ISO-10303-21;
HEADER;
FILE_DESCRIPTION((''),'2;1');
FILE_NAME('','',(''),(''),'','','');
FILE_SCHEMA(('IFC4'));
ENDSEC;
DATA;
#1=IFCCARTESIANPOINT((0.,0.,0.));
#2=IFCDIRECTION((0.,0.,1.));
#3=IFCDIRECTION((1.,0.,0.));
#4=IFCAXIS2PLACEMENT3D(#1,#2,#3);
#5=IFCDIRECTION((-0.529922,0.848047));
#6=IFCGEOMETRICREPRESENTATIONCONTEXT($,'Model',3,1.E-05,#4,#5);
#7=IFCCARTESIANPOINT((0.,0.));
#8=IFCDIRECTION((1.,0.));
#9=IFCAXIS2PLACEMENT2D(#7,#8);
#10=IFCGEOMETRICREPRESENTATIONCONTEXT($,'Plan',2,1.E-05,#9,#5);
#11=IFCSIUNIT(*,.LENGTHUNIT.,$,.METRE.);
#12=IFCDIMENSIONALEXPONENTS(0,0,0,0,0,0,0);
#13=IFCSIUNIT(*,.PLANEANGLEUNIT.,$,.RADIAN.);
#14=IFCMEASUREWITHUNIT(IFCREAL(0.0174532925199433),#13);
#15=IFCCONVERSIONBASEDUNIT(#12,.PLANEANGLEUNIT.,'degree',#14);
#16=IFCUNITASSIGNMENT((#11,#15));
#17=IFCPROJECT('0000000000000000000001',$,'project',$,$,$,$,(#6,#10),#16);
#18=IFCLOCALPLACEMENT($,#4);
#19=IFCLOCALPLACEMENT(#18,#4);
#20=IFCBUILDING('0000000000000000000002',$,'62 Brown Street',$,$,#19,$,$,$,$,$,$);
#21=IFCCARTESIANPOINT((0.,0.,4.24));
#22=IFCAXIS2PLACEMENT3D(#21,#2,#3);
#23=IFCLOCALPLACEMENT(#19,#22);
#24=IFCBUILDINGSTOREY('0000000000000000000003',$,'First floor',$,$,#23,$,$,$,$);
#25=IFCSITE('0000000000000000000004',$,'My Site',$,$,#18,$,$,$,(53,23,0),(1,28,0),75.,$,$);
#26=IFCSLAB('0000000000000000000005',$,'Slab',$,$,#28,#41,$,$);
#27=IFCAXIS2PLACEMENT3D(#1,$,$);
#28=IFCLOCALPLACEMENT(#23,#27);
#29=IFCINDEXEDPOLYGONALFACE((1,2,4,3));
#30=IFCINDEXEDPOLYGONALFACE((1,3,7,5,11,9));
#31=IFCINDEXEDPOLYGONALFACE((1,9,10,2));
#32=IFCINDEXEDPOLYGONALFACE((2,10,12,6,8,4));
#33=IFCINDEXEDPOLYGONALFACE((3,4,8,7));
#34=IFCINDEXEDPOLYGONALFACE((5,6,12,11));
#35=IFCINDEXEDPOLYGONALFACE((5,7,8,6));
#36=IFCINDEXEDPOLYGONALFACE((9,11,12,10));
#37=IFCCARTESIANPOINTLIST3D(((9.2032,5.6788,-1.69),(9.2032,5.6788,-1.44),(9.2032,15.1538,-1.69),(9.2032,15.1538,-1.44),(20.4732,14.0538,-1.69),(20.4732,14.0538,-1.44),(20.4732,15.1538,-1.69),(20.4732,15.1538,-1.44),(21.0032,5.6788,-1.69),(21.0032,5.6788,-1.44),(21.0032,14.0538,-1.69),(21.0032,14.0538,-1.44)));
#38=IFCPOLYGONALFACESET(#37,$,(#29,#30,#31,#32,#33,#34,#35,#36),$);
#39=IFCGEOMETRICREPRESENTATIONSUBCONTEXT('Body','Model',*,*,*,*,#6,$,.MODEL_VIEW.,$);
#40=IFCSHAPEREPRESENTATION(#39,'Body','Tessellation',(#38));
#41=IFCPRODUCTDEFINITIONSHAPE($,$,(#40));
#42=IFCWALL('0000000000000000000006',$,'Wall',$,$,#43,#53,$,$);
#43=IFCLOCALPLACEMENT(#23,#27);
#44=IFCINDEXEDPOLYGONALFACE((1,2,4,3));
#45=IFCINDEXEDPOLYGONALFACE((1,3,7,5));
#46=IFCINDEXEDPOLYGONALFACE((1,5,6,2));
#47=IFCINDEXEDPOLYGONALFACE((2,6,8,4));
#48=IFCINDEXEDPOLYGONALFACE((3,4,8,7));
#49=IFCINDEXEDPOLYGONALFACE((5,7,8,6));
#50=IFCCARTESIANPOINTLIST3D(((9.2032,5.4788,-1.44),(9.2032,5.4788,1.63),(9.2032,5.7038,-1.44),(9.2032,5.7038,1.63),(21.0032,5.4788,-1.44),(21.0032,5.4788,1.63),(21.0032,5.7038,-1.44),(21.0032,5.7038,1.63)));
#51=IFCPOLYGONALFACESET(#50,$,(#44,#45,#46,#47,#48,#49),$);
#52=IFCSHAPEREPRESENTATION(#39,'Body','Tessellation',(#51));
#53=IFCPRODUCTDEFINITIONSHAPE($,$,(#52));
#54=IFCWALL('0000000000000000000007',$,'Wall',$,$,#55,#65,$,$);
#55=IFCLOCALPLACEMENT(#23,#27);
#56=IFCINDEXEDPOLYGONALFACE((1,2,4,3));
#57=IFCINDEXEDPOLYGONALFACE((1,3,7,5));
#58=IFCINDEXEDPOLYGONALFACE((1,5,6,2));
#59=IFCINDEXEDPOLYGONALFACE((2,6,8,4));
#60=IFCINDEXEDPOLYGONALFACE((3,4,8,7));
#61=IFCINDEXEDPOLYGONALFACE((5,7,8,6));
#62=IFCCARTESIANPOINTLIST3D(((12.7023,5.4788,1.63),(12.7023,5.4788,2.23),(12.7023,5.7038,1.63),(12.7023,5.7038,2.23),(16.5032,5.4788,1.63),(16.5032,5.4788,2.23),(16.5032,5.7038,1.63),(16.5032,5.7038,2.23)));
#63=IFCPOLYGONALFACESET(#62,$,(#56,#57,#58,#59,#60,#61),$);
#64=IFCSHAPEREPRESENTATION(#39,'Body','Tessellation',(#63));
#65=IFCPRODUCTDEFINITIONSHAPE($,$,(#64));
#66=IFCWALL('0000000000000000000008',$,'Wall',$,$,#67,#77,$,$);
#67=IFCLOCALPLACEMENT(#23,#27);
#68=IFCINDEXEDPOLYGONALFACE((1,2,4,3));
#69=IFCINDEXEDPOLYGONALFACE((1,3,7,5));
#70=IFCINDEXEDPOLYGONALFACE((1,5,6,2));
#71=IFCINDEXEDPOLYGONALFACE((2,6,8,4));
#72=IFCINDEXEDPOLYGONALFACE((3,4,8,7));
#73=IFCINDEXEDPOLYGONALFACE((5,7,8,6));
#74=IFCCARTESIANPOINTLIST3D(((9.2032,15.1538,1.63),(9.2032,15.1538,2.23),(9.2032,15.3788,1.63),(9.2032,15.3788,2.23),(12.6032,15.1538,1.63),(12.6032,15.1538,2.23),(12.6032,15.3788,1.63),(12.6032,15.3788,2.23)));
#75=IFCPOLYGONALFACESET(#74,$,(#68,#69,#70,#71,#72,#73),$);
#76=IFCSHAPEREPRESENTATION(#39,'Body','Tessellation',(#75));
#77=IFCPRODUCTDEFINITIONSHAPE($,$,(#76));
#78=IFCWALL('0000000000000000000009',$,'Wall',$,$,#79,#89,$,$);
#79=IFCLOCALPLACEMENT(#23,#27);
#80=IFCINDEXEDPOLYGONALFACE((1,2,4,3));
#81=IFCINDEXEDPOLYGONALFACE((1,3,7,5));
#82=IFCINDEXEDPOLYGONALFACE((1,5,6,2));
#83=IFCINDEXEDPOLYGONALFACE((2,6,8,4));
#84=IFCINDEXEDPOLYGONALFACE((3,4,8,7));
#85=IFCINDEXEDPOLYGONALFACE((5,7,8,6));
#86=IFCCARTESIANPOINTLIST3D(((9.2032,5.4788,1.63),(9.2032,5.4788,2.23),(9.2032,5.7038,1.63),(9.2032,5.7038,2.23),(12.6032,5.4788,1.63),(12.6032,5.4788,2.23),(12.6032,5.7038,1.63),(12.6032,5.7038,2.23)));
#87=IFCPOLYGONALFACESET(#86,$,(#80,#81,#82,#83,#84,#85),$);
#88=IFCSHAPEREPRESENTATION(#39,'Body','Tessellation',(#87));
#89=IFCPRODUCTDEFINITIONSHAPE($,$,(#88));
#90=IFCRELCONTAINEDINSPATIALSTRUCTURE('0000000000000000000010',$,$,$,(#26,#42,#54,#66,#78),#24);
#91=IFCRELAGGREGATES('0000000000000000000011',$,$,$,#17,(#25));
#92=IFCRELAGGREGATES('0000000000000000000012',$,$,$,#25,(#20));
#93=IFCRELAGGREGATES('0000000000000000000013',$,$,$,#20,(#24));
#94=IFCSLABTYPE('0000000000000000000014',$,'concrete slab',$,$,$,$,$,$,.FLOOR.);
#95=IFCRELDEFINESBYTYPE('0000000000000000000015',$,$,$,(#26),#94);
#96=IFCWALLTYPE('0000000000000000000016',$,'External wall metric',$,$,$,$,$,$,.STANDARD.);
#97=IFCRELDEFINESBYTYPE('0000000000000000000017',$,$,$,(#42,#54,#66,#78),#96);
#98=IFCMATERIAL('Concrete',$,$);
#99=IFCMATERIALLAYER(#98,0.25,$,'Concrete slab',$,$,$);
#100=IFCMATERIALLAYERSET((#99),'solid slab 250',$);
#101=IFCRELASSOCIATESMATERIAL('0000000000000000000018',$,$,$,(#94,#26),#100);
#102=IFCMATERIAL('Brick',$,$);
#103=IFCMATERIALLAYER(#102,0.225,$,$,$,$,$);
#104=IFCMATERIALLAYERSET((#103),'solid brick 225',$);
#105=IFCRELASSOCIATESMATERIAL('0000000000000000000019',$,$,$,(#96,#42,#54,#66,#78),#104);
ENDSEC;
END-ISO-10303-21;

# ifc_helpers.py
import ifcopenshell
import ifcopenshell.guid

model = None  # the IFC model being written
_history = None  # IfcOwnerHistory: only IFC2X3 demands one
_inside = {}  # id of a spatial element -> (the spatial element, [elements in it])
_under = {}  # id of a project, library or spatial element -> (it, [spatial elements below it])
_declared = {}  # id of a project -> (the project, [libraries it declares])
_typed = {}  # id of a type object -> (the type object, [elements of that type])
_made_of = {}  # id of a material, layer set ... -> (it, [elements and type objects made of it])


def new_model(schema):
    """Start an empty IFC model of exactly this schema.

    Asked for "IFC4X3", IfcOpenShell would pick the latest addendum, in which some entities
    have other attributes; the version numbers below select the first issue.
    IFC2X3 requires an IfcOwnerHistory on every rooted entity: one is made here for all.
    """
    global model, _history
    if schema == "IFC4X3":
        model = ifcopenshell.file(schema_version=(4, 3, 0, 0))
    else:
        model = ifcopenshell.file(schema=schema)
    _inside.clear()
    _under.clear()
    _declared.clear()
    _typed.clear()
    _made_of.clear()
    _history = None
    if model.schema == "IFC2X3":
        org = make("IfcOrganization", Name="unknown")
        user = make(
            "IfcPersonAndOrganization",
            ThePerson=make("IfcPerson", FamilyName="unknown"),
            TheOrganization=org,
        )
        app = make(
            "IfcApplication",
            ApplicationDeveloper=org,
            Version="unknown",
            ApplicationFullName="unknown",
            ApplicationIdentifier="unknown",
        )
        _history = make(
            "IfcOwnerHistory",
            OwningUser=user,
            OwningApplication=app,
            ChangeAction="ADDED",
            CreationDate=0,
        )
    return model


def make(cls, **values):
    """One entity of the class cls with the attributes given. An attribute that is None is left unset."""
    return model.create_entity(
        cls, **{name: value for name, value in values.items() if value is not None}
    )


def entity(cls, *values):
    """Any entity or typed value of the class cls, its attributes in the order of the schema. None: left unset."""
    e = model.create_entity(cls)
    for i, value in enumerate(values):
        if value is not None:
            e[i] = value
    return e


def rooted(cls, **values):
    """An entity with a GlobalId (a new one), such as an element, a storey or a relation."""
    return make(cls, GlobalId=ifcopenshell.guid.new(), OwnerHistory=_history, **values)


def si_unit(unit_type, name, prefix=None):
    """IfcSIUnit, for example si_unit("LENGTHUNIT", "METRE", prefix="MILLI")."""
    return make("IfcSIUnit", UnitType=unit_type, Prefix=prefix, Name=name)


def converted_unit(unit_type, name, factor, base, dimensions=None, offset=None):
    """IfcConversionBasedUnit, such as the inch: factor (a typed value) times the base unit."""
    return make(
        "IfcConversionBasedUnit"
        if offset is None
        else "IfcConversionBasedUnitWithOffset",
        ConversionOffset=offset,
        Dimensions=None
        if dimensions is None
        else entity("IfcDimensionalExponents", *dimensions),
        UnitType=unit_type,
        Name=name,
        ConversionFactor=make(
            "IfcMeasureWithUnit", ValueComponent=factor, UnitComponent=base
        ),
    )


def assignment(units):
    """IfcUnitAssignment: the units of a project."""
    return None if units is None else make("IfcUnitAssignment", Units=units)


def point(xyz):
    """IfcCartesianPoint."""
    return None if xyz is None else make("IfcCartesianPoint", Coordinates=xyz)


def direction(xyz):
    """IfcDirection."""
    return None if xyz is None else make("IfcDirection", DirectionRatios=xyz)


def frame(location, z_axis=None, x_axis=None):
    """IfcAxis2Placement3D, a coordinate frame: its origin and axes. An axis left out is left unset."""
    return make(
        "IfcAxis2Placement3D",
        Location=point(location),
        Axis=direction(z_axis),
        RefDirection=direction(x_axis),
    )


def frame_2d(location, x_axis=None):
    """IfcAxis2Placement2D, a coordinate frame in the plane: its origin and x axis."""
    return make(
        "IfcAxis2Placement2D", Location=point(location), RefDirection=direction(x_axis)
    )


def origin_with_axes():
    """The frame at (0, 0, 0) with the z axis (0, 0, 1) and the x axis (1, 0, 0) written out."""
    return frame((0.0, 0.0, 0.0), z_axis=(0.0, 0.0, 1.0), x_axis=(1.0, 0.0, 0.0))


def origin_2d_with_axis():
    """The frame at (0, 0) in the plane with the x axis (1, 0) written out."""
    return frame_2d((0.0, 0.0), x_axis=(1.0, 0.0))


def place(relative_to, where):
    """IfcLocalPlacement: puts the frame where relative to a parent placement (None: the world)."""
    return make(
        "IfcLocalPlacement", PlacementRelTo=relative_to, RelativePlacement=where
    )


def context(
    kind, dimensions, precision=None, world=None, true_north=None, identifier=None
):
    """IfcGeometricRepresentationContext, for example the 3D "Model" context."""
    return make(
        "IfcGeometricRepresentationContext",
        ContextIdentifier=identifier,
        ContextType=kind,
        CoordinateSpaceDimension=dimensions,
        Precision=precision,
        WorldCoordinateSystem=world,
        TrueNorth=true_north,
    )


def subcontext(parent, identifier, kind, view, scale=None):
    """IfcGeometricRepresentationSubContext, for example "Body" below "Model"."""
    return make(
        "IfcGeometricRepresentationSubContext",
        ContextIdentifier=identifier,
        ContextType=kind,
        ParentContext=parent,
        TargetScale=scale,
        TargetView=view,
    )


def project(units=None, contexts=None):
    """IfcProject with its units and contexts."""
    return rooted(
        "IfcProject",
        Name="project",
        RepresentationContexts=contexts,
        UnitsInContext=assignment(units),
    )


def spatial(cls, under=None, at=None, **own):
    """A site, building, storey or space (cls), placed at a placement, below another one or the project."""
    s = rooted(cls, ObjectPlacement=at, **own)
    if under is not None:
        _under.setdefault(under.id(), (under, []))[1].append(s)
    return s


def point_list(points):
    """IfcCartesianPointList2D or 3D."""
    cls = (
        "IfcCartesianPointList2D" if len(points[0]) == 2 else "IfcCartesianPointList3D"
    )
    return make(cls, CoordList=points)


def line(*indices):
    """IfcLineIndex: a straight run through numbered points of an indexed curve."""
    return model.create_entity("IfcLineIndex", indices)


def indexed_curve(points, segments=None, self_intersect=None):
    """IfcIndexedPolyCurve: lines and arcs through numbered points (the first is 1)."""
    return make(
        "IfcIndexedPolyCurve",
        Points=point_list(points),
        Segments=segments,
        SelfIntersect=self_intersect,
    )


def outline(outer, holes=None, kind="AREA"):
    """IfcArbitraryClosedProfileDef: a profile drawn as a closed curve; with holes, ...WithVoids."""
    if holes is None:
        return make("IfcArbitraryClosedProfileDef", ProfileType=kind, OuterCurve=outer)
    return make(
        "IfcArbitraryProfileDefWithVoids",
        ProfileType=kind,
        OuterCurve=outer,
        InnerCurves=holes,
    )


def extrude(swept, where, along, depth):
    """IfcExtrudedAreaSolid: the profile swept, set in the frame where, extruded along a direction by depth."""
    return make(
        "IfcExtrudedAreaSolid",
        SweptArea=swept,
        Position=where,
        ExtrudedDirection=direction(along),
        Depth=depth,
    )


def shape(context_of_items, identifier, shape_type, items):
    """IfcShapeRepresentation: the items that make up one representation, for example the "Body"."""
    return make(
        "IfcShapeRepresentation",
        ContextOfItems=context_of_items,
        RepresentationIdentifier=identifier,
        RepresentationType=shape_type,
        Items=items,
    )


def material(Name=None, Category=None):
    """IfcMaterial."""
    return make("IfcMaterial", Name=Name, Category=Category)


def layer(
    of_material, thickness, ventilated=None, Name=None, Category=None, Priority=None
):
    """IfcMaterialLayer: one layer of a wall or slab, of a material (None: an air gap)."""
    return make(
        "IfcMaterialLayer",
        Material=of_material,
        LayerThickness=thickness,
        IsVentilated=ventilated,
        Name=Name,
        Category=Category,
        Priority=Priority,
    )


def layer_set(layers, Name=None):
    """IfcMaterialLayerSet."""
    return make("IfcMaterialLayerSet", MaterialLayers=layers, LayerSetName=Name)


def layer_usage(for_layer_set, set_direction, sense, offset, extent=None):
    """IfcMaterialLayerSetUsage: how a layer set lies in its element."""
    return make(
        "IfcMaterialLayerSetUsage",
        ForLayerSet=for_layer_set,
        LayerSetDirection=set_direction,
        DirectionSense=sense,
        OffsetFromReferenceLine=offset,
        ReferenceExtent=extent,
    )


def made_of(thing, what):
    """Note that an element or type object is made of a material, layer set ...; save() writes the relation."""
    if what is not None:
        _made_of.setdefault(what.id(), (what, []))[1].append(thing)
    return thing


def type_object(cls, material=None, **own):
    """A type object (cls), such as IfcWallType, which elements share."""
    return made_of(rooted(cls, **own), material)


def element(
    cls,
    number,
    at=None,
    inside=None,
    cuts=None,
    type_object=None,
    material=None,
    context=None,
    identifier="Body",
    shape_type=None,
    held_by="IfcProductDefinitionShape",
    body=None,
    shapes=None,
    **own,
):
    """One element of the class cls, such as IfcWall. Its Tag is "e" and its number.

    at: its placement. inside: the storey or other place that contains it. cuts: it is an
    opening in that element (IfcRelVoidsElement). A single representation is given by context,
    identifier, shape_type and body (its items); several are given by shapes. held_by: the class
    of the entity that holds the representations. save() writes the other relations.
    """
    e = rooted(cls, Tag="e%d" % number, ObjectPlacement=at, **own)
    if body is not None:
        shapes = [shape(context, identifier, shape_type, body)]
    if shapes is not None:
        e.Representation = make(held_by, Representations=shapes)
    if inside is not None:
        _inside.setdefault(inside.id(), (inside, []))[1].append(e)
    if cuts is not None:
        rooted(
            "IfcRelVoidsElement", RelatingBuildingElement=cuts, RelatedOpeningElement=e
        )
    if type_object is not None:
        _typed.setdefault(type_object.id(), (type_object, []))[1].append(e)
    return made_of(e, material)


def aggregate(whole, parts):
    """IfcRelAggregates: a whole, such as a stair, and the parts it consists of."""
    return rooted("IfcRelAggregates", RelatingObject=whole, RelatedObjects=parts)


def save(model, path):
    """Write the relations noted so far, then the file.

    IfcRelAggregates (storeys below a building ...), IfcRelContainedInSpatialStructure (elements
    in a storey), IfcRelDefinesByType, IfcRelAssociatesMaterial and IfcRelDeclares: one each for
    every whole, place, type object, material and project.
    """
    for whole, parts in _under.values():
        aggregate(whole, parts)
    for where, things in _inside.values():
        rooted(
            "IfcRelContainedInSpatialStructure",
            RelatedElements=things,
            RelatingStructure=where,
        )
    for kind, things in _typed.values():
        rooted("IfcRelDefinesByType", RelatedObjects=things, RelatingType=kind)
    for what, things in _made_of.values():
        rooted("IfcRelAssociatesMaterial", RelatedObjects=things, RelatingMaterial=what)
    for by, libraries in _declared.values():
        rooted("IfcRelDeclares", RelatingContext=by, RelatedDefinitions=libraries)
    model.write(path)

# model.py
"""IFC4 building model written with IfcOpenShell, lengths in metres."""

from ifc_helpers import new_model, entity, si_unit, converted_unit, direction, frame, origin_with_axes, origin_2d_with_axis, place, context, subcontext, project, spatial, line, indexed_curve, outline, extrude, material, layer, layer_set, layer_usage, type_object, element, save


model = new_model("IFC4")

# Units and contexts
model_context = context("Model", 3, precision=1e-05, world=origin_with_axes(), true_north=direction((-0.529922, 0.848047)))
plan_context = context("Plan", 2, precision=1e-05, world=origin_2d_with_axis(), true_north=direction((-0.529922, 0.848047)))
body_context_1 = subcontext(model_context, "Body", "Model", "MODEL_VIEW")
ifc_project = project(units=[si_unit("LENGTHUNIT", "METRE"), converted_unit("PLANEANGLEUNIT", "degree", entity("IfcReal", 0.0174532925199433), si_unit("PLANEANGLEUNIT", "RADIAN"), dimensions=[0, 0, 0, 0, 0, 0, 0])], contexts=[model_context, plan_context])

# Site, building, storey
site_placement = place(None, origin_with_axes())
site = spatial("IfcSite", under=ifc_project, at=site_placement, Name="My Site", RefLatitude=(53, 23, 0), RefLongitude=(1, 28, 0), RefElevation=75.0)
building_placement = place(site_placement, origin_with_axes())
building = spatial("IfcBuilding", under=site, at=building_placement, Name="62 Brown Street")
storey_placement = place(building_placement, frame((0.0, 0.0, 4.24), z_axis=(0.0, 0.0, 1.0), x_axis=(1.0, 0.0, 0.0)))
storey = spatial("IfcBuildingStorey", under=building, at=storey_placement, Name="First floor")

# Slab
ifc_material_1 = material(Name="Concrete")
ifc_layer_1 = layer(ifc_material_1, 0.25, Name="Concrete slab")
ifc_layer_set_1 = layer_set([ifc_layer_1], Name="solid slab 250")
ifc_layer_usage_1 = layer_usage(ifc_layer_set_1, "AXIS3", "POSITIVE", 0.0)
slab_type = type_object("IfcSlabType", Name="concrete slab", PredefinedType="FLOOR", material=ifc_layer_set_1)
slab_placement = place(storey_placement, frame((9.2032, 5.6788, -1.69), z_axis=(0.0, 0.0, 1.0), x_axis=(1.0, 0.0, 0.0)))
element("IfcSlab", 1, at=slab_placement, inside=storey, type_object=slab_type, material=ifc_layer_usage_1, Name="Slab", context=body_context_1, shape_type="SweptSolid", body=[
    extrude(outline(indexed_curve([(11.27, 9.475), (11.8, 0.0), (0.0, 0.0), (0.0, 9.475), (11.8, 8.375), (11.27, 8.375)], segments=[line(6, 1), line(1, 4), line(4, 3), line(3, 2), line(2, 5), line(5, 6)], self_intersect=False)), None, (0.0, 0.0, 1.0), 0.25),
])

# Walls
ifc_material_2 = material(Name="Brick")
ifc_layer_2 = layer(ifc_material_2, 0.225)
ifc_layer_set_2 = layer_set([ifc_layer_2], Name="solid brick 225")
ifc_layer_usage_2 = layer_usage(ifc_layer_set_2, "AXIS2", "POSITIVE", 0.0)
wall_type_1 = type_object("IfcWallType", Name="External wall metric", PredefinedType="STANDARD", material=ifc_layer_set_2)
wall_1_placement = place(storey_placement, frame((9.2032, 5.4788, -1.44), z_axis=(0.0, 0.0, 1.0), x_axis=(1.0, 0.0, 0.0)))
element("IfcWall", 2, at=wall_1_placement, inside=storey, type_object=wall_type_1, material=ifc_layer_usage_2, Name="Wall", context=body_context_1, shape_type="SweptSolid", body=[
    extrude(outline(indexed_curve([(0.0, 0.0), (0.0, 0.225), (11.8, 0.225), (11.8, 0.0), (0.0, 0.0)], self_intersect=False)), origin_with_axes(), (0.0, 0.0, 1.0), 3.07),
])
ifc_layer_usage_3 = layer_usage(ifc_layer_set_2, "AXIS2", "POSITIVE", 0.0)
wall_2_placement = place(storey_placement, frame((12.7023, 5.4788, 1.63), z_axis=(0.0, 0.0, 1.0), x_axis=(1.0, 0.0, 0.0)))
element("IfcWall", 3, at=wall_2_placement, inside=storey, type_object=wall_type_1, material=ifc_layer_usage_3, Name="Wall", context=body_context_1, shape_type="SweptSolid", body=[
    extrude(outline(indexed_curve([(0.0, 0.0), (0.0, 0.225), (3.8009, 0.225), (3.8009, 0.0), (0.0, 0.0)], self_intersect=False)), origin_with_axes(), (0.0, 0.0, 1.0), 0.6),
])
ifc_layer_usage_4 = layer_usage(ifc_layer_set_2, "AXIS2", "POSITIVE", 0.0)
wall_3_placement = place(storey_placement, frame((12.6032, 15.3788, 1.63), z_axis=(0.0, 0.0, 1.0), x_axis=(-1.0, 0.0, 0.0)))
element("IfcWall", 4, at=wall_3_placement, inside=storey, type_object=wall_type_1, material=ifc_layer_usage_4, Name="Wall", context=body_context_1, shape_type="SweptSolid", body=[
    extrude(outline(indexed_curve([(0.0, 0.0), (0.0, 0.225), (3.4, 0.225), (3.4, 0.0), (0.0, 0.0)], self_intersect=False)), origin_with_axes(), (0.0, 0.0, 1.0), 0.6),
])
ifc_layer_usage_5 = layer_usage(ifc_layer_set_2, "AXIS2", "POSITIVE", 0.0)
wall_4_placement = place(storey_placement, frame((9.2032, 5.4788, 1.63), z_axis=(0.0, 0.0, 1.0), x_axis=(1.0, 0.0, 0.0)))
element("IfcWall", 5, at=wall_4_placement, inside=storey, type_object=wall_type_1, material=ifc_layer_usage_5, Name="Wall", context=body_context_1, shape_type="SweptSolid", body=[
    extrude(outline(indexed_curve([(0.0, 0.0), (0.0, 0.225), (3.4, 0.225), (3.4, 0.0), (0.0, 0.0)], self_intersect=False)), origin_with_axes(), (0.0, 0.0, 1.0), 0.6),
])

save(model, "model.ifc")
